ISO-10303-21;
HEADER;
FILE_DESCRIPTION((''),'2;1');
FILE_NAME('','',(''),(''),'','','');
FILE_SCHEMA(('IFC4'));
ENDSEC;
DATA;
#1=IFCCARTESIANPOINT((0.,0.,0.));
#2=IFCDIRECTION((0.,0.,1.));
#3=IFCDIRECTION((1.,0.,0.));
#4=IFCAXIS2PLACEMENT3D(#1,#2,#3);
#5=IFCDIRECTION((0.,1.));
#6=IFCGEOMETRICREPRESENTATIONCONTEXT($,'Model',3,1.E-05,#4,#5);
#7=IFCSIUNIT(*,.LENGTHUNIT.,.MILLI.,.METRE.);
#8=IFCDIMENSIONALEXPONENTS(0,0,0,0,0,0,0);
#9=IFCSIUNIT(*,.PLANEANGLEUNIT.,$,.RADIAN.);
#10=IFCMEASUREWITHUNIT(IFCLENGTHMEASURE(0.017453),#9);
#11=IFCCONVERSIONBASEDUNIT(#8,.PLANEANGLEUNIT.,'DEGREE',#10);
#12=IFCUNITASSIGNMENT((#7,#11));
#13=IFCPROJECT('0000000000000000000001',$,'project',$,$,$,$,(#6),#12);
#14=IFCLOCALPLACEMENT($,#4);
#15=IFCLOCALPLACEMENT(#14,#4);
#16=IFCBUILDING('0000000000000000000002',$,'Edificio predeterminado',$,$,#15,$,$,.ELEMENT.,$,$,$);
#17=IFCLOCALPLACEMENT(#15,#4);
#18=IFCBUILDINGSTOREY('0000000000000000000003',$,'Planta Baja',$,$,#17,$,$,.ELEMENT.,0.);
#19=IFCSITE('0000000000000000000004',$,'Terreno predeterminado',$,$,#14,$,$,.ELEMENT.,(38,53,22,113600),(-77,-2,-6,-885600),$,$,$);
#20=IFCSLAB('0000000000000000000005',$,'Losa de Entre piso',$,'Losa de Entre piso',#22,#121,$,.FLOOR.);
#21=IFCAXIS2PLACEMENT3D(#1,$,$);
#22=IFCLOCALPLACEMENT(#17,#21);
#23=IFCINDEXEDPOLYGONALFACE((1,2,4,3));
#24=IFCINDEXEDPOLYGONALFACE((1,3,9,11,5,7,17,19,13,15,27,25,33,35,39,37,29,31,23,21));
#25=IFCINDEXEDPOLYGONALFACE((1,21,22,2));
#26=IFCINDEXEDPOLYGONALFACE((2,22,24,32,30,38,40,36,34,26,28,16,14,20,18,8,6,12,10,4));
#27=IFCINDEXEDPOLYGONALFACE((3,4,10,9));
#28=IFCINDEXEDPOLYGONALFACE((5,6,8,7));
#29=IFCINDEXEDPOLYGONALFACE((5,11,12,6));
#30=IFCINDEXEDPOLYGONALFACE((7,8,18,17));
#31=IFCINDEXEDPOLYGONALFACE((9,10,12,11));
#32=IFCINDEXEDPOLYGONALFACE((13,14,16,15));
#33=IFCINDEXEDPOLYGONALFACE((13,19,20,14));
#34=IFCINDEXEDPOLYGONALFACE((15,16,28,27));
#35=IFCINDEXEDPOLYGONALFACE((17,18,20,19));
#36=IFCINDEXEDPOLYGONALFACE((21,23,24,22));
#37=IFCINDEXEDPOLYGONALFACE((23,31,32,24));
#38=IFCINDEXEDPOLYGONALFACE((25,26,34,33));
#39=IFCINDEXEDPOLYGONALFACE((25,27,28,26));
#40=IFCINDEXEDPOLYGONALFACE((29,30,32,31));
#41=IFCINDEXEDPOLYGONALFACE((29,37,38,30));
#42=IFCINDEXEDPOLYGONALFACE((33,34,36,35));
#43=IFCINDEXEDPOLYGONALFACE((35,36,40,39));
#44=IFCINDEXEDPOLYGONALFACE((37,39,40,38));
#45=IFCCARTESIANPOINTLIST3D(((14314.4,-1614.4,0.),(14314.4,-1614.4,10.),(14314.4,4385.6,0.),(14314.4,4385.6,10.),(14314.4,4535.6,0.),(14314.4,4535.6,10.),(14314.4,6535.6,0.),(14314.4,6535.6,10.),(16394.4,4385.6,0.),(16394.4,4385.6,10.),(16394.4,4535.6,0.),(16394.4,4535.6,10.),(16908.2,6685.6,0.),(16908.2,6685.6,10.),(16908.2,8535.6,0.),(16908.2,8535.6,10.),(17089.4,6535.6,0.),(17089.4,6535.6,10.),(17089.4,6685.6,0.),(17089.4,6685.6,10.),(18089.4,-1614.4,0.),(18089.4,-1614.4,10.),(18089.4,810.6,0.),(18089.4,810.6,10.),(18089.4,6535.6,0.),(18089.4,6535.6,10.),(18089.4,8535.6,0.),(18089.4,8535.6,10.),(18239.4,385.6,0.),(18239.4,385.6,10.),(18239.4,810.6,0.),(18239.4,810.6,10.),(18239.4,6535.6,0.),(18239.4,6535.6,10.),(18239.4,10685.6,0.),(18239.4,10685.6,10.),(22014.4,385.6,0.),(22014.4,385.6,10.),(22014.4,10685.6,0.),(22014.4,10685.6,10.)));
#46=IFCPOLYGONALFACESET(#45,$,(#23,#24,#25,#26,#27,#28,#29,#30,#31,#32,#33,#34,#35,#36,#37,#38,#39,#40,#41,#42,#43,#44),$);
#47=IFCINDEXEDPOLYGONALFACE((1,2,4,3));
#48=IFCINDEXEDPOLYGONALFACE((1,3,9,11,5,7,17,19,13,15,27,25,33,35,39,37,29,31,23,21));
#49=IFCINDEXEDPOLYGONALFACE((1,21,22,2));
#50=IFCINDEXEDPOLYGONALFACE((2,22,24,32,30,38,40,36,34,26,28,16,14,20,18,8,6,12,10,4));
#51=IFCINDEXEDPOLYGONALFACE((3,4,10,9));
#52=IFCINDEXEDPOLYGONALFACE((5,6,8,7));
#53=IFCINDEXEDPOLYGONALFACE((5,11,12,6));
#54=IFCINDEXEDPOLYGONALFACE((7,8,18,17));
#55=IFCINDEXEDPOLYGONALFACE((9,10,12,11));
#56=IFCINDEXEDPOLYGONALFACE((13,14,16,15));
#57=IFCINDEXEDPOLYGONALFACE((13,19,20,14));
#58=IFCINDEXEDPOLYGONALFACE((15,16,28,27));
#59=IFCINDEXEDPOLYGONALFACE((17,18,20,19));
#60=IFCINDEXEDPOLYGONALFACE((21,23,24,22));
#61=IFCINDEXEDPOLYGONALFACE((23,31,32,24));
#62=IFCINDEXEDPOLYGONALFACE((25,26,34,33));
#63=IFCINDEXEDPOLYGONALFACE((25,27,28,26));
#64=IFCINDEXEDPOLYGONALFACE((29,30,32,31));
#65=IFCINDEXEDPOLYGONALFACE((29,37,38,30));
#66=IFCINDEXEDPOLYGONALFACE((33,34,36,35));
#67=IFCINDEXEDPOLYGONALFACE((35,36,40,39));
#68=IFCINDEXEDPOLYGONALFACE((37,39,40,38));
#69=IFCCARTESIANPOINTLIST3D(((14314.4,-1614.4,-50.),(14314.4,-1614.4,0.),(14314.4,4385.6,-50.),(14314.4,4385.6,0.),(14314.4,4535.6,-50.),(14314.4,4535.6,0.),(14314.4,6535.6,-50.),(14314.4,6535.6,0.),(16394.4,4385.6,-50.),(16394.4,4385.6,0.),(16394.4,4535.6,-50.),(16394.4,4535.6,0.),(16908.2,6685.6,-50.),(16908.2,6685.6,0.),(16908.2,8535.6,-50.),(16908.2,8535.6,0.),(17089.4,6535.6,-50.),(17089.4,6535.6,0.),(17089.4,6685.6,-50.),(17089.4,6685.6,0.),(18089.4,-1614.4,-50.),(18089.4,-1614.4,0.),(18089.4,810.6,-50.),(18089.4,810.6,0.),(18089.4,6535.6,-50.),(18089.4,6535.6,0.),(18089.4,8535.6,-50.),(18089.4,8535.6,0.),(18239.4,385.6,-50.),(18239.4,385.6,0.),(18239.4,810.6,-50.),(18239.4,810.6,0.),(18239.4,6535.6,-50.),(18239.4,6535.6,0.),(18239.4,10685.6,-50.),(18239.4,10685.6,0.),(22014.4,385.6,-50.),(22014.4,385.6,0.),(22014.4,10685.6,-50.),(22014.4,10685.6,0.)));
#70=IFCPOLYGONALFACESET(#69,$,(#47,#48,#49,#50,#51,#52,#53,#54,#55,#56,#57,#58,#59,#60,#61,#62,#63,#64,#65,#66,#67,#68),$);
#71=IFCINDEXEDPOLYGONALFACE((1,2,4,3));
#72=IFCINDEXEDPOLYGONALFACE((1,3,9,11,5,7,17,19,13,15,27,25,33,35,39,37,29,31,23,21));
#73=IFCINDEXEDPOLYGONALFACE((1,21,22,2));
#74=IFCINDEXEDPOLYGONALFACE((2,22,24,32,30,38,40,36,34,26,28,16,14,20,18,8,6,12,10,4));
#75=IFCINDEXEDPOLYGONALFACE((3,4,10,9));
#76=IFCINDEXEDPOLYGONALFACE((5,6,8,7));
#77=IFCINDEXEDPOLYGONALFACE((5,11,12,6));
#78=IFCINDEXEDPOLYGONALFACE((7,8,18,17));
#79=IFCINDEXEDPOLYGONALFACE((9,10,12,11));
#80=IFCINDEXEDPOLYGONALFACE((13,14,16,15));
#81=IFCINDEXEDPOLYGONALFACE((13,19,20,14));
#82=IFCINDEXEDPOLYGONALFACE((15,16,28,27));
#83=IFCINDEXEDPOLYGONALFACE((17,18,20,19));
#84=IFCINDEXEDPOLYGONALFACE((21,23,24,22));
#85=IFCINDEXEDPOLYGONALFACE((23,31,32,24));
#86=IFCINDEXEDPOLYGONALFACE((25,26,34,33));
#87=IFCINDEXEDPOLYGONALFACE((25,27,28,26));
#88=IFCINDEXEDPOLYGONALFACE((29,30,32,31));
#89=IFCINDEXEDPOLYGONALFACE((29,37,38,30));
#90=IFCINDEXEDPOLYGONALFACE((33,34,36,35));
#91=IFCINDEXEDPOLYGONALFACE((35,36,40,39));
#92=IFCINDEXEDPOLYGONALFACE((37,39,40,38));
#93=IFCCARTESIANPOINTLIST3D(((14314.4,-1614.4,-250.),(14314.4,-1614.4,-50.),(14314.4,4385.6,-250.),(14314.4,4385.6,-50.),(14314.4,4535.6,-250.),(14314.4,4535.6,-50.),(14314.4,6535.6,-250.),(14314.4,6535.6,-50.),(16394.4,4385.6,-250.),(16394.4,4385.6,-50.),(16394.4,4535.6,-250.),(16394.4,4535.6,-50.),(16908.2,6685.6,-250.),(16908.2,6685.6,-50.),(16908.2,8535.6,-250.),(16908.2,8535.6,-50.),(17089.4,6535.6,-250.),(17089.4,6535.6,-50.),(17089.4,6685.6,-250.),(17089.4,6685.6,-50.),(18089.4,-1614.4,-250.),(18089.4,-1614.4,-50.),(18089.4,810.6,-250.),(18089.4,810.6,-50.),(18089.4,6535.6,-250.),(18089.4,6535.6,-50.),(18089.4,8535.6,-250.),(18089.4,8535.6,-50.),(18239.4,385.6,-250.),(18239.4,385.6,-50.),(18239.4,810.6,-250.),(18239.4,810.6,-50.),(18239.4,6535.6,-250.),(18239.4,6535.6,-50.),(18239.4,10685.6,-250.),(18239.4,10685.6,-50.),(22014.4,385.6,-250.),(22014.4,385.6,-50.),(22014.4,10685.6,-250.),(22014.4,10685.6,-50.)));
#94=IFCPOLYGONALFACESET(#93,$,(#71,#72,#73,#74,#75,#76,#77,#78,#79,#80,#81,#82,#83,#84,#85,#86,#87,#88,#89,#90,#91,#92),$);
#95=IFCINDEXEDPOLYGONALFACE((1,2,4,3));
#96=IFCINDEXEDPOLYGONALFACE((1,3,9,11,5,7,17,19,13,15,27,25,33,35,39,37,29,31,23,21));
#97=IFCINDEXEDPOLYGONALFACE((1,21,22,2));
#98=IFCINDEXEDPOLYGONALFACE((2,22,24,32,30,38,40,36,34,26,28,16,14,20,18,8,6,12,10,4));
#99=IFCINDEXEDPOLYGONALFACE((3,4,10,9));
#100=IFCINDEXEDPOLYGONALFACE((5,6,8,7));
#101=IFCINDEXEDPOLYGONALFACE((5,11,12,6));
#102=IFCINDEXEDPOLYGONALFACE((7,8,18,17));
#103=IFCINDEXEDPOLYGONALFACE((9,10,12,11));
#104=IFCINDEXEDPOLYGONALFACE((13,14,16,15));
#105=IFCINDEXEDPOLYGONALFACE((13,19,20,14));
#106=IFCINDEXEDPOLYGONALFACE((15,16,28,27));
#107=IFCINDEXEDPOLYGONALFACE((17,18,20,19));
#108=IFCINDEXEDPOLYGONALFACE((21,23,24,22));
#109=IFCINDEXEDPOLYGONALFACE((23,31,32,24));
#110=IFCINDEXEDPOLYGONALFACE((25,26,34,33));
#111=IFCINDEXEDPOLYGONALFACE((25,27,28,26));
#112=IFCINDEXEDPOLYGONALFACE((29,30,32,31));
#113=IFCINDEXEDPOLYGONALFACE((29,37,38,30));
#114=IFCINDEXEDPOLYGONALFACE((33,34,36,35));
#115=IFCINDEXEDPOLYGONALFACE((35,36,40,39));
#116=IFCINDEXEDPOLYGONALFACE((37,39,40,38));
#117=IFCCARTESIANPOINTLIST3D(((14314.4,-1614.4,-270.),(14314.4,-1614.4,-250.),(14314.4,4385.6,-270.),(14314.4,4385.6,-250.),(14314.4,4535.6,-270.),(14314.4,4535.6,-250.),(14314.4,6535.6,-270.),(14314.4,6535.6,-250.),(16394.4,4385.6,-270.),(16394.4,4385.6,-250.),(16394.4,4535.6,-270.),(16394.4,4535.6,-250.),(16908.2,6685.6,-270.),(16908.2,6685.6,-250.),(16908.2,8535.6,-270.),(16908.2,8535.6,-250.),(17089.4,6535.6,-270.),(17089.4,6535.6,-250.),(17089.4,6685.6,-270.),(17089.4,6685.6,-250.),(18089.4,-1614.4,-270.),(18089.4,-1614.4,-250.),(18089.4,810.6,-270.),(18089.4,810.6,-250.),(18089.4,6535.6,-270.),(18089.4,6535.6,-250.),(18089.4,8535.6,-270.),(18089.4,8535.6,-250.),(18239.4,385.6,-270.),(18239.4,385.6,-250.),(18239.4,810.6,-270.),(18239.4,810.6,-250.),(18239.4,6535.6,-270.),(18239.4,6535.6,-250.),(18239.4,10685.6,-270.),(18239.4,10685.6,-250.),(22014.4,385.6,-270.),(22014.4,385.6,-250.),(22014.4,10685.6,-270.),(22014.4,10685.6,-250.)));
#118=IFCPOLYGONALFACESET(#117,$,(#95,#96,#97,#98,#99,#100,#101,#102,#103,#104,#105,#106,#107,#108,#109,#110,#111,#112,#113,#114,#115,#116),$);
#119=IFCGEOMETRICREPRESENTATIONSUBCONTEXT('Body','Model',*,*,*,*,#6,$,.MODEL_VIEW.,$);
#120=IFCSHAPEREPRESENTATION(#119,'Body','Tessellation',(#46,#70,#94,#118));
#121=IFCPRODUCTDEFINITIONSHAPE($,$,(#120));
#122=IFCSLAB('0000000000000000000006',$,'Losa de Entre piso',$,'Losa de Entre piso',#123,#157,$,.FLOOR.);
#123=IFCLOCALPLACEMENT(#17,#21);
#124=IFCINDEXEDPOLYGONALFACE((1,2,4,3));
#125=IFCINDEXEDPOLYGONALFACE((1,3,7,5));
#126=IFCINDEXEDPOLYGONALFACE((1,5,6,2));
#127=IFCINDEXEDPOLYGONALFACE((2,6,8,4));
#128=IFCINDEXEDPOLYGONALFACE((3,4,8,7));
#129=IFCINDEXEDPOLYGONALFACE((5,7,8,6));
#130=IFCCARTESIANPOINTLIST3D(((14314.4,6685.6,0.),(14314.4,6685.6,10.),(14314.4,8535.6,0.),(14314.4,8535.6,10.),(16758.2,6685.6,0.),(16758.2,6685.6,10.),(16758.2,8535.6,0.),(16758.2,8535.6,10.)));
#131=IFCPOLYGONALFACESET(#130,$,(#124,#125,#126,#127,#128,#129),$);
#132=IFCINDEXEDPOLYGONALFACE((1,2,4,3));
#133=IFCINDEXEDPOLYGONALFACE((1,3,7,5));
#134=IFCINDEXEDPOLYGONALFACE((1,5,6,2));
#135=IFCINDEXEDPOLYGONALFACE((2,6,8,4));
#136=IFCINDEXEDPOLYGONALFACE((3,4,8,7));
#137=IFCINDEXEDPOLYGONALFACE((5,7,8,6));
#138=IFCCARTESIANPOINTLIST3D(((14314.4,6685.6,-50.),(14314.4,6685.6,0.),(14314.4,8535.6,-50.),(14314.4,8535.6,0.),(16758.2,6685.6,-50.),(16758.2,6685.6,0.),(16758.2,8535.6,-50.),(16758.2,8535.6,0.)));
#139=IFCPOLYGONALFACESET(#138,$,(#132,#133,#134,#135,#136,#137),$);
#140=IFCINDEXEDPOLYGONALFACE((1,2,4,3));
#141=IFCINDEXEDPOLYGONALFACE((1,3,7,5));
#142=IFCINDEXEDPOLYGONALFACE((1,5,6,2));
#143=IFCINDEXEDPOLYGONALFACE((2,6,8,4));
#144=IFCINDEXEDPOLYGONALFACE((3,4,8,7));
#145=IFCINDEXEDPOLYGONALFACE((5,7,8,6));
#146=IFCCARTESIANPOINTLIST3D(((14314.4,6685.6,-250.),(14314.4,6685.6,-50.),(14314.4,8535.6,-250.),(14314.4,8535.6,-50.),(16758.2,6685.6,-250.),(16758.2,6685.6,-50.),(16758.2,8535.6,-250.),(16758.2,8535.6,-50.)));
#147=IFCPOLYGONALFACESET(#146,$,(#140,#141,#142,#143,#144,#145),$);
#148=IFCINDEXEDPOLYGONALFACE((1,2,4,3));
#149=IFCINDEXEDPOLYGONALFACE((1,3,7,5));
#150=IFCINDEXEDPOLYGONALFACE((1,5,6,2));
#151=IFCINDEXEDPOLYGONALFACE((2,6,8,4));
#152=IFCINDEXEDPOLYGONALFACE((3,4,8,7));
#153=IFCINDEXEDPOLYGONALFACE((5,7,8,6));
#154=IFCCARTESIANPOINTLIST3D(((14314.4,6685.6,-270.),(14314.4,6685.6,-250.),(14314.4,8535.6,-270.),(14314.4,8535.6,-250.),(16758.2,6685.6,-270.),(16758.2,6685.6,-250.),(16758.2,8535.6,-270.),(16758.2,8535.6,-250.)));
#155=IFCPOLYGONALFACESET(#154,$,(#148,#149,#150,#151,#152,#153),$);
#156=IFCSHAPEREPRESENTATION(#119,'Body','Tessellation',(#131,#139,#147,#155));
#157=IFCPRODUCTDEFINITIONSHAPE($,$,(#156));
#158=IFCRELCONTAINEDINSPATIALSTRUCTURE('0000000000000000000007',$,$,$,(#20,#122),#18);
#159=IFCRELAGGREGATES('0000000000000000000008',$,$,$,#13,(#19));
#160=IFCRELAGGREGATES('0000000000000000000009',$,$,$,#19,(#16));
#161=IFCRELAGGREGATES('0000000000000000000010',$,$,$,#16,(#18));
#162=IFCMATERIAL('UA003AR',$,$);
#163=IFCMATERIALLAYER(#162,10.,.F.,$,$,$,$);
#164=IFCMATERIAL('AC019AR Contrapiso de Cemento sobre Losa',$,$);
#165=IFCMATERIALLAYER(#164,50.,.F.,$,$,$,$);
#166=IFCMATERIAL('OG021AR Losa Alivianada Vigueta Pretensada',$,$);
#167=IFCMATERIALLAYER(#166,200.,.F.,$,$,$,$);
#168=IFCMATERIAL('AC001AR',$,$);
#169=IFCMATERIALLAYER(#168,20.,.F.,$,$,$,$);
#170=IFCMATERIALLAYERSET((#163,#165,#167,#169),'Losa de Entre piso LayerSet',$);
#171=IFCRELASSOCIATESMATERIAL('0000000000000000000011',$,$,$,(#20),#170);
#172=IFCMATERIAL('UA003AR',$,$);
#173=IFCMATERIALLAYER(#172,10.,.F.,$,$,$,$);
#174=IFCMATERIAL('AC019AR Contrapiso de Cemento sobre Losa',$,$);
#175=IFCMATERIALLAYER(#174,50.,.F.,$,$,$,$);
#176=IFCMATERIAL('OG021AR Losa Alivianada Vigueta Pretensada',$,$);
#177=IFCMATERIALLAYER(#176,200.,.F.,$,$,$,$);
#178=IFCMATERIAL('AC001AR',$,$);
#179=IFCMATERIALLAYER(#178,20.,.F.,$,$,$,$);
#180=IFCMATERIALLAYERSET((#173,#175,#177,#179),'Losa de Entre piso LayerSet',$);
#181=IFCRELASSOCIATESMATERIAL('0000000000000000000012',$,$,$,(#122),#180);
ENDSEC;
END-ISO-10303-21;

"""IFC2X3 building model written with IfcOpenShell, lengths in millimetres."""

from ifc_helpers import new_model, entity, si_unit, converted_unit, direction, frame, origin_with_axes, place, context, subcontext, project, spatial, polyline, outline, extrude, material, layer, layer_set, layer_usage, element, save


model = new_model("IFC2X3")

# Units and contexts
model_context = context("Model", 3, precision=1e-05, world=origin_with_axes(), true_north=direction((0.0, 1.0)))
body_context = subcontext(model_context, "Body", "Model", "MODEL_VIEW")
ifc_project = project(units=[si_unit("LENGTHUNIT", "METRE", prefix="MILLI"), converted_unit("PLANEANGLEUNIT", "DEGREE", entity("IfcLengthMeasure", 0.017453), si_unit("PLANEANGLEUNIT", "RADIAN"), dimensions=[0, 0, 0, 0, 0, 0, 0])], contexts=[model_context])

# Site, building, storey
site_placement = place(None, origin_with_axes())
site = spatial("IfcSite", under=ifc_project, at=site_placement, Name="Terreno predeterminado", CompositionType="ELEMENT", RefLatitude=(38, 53, 22, 113600), RefLongitude=(-77, -2, -6, -885600))
building_placement = place(site_placement, origin_with_axes())
building = spatial("IfcBuilding", under=site, at=building_placement, Name="Edificio predeterminado", CompositionType="ELEMENT")
storey_placement = place(building_placement, origin_with_axes())
storey = spatial("IfcBuildingStorey", under=building, at=storey_placement, Name="Planta Baja", CompositionType="ELEMENT", Elevation=0.0)

# Slabs
ifc_material_1 = material(Name="UA003AR")
ifc_layer_1 = layer(ifc_material_1, 10.0, ventilated=False)
ifc_material_2 = material(Name="AC019AR Contrapiso de Cemento sobre Losa")
ifc_layer_2 = layer(ifc_material_2, 50.0, ventilated=False)
ifc_material_3 = material(Name="OG021AR Losa Alivianada Vigueta Pretensada")
ifc_layer_3 = layer(ifc_material_3, 200.0, ventilated=False)
ifc_material_4 = material(Name="AC001AR")
ifc_layer_4 = layer(ifc_material_4, 20.0, ventilated=False)
ifc_layer_set_1 = layer_set([ifc_layer_1, ifc_layer_2, ifc_layer_3, ifc_layer_4], Name="Losa de Entre piso LayerSet")
ifc_layer_usage_1 = layer_usage(ifc_layer_set_1, "AXIS3", "POSITIVE", 0.0)
slab_1_placement = place(storey_placement, origin_with_axes())
element("IfcSlab", 1, at=slab_1_placement, inside=storey, material=ifc_layer_usage_1, Name="Losa de Entre piso", ObjectType="Losa de Entre piso", PredefinedType="FLOOR", context=body_context, shape_type="SweptSolid", body=[
    extrude(outline(polyline([(0.0, -6000.0), (3775.0, -6000.0), (3775.0, -3575.0), (3925.0, -3575.0), (3925.0, -4000.0), (7700.0, -4000.0), (7700.0, 6300.0), (3925.0, 6300.0), (3925.0, 2150.0), (3775.0, 2150.0), (3775.0, 4150.0), (2593.9, 4150.0), (2593.9, 2300.0), (2775.0, 2300.0), (2775.0, 2150.0), (0.0, 2150.0), (0.0, 150.0), (2080.0, 150.0), (2080.0, 0.0), (0.0, 0.0), (0.0, -6000.0)])), frame((14314.4, 4385.6, 0.0), z_axis=(0.0, 0.0, 1.0), x_axis=(1.0, 0.0, 0.0)), (0.0, 0.0, 1.0), 10.0),
    extrude(outline(polyline([(0.0, -6000.0), (3775.0, -6000.0), (3775.0, -3575.0), (3925.0, -3575.0), (3925.0, -4000.0), (7700.0, -4000.0), (7700.0, 6300.0), (3925.0, 6300.0), (3925.0, 2150.0), (3775.0, 2150.0), (3775.0, 4150.0), (2593.9, 4150.0), (2593.9, 2300.0), (2775.0, 2300.0), (2775.0, 2150.0), (0.0, 2150.0), (0.0, 150.0), (2080.0, 150.0), (2080.0, 0.0), (0.0, 0.0), (0.0, -6000.0)])), frame((14314.4, 4385.6, -50.0), z_axis=(0.0, 0.0, 1.0), x_axis=(1.0, 0.0, 0.0)), (0.0, 0.0, 1.0), 50.0),
    extrude(outline(polyline([(0.0, -6000.0), (3775.0, -6000.0), (3775.0, -3575.0), (3925.0, -3575.0), (3925.0, -4000.0), (7700.0, -4000.0), (7700.0, 6300.0), (3925.0, 6300.0), (3925.0, 2150.0), (3775.0, 2150.0), (3775.0, 4150.0), (2593.9, 4150.0), (2593.9, 2300.0), (2775.0, 2300.0), (2775.0, 2150.0), (0.0, 2150.0), (0.0, 150.0), (2080.0, 150.0), (2080.0, 0.0), (0.0, 0.0), (0.0, -6000.0)])), frame((14314.4, 4385.6, -250.0), z_axis=(0.0, 0.0, 1.0), x_axis=(1.0, 0.0, 0.0)), (0.0, 0.0, 1.0), 200.0),
    extrude(outline(polyline([(0.0, -6000.0), (3775.0, -6000.0), (3775.0, -3575.0), (3925.0, -3575.0), (3925.0, -4000.0), (7700.0, -4000.0), (7700.0, 6300.0), (3925.0, 6300.0), (3925.0, 2150.0), (3775.0, 2150.0), (3775.0, 4150.0), (2593.9, 4150.0), (2593.9, 2300.0), (2775.0, 2300.0), (2775.0, 2150.0), (0.0, 2150.0), (0.0, 150.0), (2080.0, 150.0), (2080.0, 0.0), (0.0, 0.0), (0.0, -6000.0)])), frame((14314.4, 4385.6, -270.0), z_axis=(0.0, 0.0, 1.0), x_axis=(1.0, 0.0, 0.0)), (0.0, 0.0, 1.0), 20.0),
])
ifc_material_5 = material(Name="UA003AR")
ifc_layer_5 = layer(ifc_material_5, 10.0, ventilated=False)
ifc_material_6 = material(Name="AC019AR Contrapiso de Cemento sobre Losa")
ifc_layer_6 = layer(ifc_material_6, 50.0, ventilated=False)
ifc_material_7 = material(Name="OG021AR Losa Alivianada Vigueta Pretensada")
ifc_layer_7 = layer(ifc_material_7, 200.0, ventilated=False)
ifc_material_8 = material(Name="AC001AR")
ifc_layer_8 = layer(ifc_material_8, 20.0, ventilated=False)
ifc_layer_set_2 = layer_set([ifc_layer_5, ifc_layer_6, ifc_layer_7, ifc_layer_8], Name="Losa de Entre piso LayerSet")
ifc_layer_usage_2 = layer_usage(ifc_layer_set_2, "AXIS3", "NEGATIVE", 0.0)
slab_2_placement = place(storey_placement, origin_with_axes())
element("IfcSlab", 2, at=slab_2_placement, inside=storey, material=ifc_layer_usage_2, Name="Losa de Entre piso", ObjectType="Losa de Entre piso", PredefinedType="FLOOR", context=body_context, shape_type="SweptSolid", body=[
    extrude(outline(polyline([(0.0, 2443.9), (1850.0, 2443.9), (1850.0, 0.0), (0.0, 0.0), (0.0, 2443.9)])), frame((14314.4, 6685.6, 0.0), z_axis=(0.0, 0.0, -1.0), x_axis=(0.0, 1.0, 0.0)), (0.0, 0.0, -1.0), 10.0),
    extrude(outline(polyline([(0.0, 2443.9), (1850.0, 2443.9), (1850.0, 0.0), (0.0, 0.0), (0.0, 2443.9)])), frame((14314.4, 6685.6, -50.0), z_axis=(0.0, 0.0, -1.0), x_axis=(0.0, 1.0, 0.0)), (0.0, 0.0, -1.0), 50.0),
    extrude(outline(polyline([(0.0, 2443.9), (1850.0, 2443.9), (1850.0, 0.0), (0.0, 0.0), (0.0, 2443.9)])), frame((14314.4, 6685.6, -250.0), z_axis=(0.0, 0.0, -1.0), x_axis=(0.0, 1.0, 0.0)), (0.0, 0.0, -1.0), 200.0),
    extrude(outline(polyline([(0.0, 2443.9), (1850.0, 2443.9), (1850.0, 0.0), (0.0, 0.0), (0.0, 2443.9)])), frame((14314.4, 6685.6, -270.0), z_axis=(0.0, 0.0, -1.0), x_axis=(0.0, 1.0, 0.0)), (0.0, 0.0, -1.0), 20.0),
])

save(model, "model.ifc")
